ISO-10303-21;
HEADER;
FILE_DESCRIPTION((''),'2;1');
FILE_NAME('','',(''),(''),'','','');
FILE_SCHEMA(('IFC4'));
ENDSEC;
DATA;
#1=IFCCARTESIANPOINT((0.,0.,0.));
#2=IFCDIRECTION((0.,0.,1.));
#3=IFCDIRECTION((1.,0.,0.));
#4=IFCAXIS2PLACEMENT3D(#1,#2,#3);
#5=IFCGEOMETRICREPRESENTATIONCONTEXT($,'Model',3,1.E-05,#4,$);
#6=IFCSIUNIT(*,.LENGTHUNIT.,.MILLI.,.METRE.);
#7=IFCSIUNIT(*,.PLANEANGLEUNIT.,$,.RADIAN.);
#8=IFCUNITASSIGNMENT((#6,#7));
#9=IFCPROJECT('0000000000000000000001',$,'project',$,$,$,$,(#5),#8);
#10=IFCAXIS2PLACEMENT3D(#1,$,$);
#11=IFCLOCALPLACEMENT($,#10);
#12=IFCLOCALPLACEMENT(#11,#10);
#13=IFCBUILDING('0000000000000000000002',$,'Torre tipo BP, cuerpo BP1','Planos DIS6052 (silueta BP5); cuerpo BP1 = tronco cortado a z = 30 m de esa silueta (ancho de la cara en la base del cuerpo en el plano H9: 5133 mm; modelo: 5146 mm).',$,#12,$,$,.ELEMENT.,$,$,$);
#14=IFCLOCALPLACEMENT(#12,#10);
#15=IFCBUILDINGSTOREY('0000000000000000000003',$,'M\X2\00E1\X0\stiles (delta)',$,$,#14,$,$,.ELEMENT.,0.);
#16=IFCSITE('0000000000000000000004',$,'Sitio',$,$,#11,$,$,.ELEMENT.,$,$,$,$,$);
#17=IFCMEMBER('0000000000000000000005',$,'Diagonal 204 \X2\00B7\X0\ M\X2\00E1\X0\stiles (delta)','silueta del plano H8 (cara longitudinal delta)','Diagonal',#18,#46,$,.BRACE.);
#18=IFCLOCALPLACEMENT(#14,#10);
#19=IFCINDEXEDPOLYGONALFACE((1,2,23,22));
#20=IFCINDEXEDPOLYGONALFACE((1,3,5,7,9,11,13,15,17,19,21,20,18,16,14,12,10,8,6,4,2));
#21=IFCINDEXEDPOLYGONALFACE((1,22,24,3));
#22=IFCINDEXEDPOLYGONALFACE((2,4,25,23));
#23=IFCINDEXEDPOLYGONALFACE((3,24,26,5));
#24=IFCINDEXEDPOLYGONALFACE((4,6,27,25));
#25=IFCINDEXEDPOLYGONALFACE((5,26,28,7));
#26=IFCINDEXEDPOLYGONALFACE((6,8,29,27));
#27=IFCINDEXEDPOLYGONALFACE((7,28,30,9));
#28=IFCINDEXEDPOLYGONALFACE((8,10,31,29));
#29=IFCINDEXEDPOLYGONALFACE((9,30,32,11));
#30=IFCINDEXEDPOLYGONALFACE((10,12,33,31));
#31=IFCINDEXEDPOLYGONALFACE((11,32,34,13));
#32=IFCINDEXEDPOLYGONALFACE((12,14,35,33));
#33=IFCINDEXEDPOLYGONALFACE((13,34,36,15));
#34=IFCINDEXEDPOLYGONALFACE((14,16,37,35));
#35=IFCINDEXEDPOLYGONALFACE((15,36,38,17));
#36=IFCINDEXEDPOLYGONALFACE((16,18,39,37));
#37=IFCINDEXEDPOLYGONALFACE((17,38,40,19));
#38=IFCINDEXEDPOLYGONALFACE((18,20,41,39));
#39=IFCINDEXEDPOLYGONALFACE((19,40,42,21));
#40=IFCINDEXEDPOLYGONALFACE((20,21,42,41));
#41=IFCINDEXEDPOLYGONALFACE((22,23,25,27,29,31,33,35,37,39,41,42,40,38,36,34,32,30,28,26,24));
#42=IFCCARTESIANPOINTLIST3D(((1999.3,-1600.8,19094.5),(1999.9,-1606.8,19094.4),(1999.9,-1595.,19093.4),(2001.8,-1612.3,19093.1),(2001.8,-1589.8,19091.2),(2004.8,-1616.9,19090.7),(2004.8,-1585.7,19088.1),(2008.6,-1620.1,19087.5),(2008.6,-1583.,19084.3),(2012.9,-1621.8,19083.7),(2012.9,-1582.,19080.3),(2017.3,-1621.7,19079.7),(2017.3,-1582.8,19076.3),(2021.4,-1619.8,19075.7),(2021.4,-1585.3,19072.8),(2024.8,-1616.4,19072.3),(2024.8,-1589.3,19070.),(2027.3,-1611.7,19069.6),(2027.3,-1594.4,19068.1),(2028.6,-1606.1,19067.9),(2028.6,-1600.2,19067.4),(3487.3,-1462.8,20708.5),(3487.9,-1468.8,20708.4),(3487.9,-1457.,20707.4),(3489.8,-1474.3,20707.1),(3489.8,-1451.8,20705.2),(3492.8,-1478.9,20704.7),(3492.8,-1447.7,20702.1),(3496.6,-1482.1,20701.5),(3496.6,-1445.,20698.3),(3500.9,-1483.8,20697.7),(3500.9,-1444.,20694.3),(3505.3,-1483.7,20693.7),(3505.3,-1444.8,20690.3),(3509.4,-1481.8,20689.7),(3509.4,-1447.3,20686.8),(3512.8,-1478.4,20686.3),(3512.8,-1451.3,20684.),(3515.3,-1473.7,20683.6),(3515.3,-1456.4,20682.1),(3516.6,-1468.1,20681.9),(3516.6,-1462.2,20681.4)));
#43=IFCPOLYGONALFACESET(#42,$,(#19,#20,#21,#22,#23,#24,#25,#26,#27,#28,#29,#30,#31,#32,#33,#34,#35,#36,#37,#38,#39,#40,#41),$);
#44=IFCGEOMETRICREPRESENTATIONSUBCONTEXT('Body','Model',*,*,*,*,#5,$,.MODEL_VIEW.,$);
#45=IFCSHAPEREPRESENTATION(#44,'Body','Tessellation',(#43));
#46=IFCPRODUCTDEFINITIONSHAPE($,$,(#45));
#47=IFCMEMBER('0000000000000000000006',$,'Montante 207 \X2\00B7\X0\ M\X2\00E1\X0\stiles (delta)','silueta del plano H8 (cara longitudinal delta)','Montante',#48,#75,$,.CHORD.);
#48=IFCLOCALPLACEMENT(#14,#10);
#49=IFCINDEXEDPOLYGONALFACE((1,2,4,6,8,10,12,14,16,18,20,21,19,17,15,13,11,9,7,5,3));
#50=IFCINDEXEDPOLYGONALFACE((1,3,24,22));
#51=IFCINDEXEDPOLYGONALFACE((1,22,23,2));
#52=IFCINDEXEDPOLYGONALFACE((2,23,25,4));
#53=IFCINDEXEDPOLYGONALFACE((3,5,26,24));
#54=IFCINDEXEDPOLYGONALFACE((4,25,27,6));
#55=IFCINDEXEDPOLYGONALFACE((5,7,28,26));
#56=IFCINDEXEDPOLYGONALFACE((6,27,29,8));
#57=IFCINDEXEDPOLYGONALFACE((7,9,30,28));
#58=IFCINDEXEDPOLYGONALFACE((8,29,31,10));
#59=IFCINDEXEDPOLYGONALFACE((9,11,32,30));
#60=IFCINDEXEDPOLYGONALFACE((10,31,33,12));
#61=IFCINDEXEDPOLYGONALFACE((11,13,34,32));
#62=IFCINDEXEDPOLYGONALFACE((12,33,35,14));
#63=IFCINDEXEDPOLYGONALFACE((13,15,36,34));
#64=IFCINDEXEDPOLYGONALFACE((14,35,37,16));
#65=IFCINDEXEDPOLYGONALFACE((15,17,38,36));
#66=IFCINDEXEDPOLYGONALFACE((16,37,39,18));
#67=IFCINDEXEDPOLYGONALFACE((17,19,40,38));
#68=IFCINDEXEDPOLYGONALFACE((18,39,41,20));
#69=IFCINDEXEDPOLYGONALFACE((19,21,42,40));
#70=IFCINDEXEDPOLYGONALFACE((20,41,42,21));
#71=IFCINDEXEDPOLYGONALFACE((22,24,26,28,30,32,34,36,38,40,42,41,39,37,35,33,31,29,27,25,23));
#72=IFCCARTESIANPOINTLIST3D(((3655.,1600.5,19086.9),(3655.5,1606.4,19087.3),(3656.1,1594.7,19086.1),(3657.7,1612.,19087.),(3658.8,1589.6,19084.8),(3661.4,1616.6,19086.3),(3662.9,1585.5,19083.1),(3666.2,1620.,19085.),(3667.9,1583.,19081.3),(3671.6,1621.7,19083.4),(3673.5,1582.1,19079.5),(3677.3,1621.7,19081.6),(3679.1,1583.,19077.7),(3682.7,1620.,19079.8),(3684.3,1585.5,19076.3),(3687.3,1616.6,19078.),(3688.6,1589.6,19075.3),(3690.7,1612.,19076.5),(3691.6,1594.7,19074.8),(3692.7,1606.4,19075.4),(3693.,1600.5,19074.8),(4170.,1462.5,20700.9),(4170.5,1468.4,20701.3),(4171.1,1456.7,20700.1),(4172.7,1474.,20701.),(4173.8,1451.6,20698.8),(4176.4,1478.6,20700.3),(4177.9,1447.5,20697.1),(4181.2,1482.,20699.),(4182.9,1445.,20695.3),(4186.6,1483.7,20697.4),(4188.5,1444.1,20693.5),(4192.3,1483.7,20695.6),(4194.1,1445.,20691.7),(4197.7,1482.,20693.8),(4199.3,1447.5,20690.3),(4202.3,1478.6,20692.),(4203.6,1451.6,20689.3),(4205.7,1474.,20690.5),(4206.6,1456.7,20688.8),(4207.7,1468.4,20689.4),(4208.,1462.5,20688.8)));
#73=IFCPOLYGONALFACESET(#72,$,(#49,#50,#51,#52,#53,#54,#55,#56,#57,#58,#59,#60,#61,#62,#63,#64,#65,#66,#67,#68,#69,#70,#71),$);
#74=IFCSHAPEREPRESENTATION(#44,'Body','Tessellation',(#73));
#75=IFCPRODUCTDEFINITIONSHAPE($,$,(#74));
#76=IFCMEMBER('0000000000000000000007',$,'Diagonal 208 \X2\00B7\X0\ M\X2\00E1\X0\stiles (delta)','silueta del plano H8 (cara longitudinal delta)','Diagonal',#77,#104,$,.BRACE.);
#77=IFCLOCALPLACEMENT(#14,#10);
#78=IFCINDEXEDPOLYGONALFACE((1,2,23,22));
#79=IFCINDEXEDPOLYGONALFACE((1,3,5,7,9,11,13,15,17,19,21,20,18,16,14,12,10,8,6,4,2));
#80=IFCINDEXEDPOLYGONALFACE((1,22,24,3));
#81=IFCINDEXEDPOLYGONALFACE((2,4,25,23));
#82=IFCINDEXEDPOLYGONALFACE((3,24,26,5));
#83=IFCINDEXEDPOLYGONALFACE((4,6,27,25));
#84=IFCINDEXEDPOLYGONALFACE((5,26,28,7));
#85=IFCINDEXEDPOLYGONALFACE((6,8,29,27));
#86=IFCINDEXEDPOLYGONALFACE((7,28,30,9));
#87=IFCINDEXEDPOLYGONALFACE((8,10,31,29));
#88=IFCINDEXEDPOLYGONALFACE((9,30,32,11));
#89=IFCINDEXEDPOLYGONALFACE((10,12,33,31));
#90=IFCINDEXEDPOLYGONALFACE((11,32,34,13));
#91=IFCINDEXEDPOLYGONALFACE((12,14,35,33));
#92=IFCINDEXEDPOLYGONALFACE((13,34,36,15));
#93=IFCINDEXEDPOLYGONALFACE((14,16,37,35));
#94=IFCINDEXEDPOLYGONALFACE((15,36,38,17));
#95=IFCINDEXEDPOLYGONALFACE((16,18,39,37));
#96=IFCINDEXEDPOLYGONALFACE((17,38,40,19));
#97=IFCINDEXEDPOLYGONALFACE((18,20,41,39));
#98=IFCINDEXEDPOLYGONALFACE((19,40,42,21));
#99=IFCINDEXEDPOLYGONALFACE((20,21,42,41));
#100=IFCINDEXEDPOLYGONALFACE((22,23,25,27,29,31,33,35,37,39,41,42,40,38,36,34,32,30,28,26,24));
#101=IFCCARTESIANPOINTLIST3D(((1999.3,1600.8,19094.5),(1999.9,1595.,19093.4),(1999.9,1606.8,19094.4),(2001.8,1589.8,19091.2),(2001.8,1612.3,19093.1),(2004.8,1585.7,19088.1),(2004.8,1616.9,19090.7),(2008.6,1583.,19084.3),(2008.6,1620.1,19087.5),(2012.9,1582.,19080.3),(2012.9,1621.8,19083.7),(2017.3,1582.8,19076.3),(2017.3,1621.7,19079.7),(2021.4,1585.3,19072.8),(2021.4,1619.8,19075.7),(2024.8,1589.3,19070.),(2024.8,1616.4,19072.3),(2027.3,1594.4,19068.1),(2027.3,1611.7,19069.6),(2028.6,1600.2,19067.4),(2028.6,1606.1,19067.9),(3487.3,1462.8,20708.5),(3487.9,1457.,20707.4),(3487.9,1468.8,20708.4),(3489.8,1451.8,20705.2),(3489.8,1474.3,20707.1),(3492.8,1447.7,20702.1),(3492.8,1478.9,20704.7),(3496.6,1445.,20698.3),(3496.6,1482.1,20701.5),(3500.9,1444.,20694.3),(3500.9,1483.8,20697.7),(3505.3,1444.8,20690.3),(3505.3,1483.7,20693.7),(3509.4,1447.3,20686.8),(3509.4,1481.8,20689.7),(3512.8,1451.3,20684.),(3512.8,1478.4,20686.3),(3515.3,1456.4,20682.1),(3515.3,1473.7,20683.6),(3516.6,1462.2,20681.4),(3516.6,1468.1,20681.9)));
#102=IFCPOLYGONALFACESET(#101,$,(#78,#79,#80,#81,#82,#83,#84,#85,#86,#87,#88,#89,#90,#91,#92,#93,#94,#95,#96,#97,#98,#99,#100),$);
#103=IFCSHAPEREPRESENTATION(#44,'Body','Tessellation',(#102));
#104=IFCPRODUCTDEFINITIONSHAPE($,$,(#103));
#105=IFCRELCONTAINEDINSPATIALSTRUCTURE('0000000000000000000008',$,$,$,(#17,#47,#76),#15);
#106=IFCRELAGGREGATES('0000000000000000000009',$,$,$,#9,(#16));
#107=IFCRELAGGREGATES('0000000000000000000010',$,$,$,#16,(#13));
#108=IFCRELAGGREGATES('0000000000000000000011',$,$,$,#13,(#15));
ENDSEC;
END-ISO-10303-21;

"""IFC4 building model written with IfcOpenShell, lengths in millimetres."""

from ifc_helpers import new_model, si_unit, frame, origin, origin_with_axes, place, context, subcontext, project, spatial, circle, extrude, element, save


model = new_model("IFC4")

# Units and contexts
model_context = context("Model", 3, precision=1e-05, world=origin_with_axes())
body_context = subcontext(model_context, "Body", "Model", "MODEL_VIEW")
ifc_project = project(units=[si_unit("LENGTHUNIT", "METRE", prefix="MILLI"), si_unit("PLANEANGLEUNIT", "RADIAN")], contexts=[model_context])

# Site, building, storey
site_placement = place(None, origin())
site = spatial("IfcSite", under=ifc_project, at=site_placement, Name="Sitio", CompositionType="ELEMENT")
building_placement = place(site_placement, origin())
building = spatial("IfcBuilding", under=site, at=building_placement, Name="Torre tipo BP, cuerpo BP1", Description="Planos DIS6052 (silueta BP5); cuerpo BP1 = tronco cortado a z = 30 m de esa silueta (ancho de la cara en la base del cuerpo en el plano H9: 5133 mm; modelo: 5146 mm).", CompositionType="ELEMENT")
storey_placement = place(building_placement, origin())
storey = spatial("IfcBuildingStorey", under=building, at=storey_placement, Name="Mástiles (delta)", CompositionType="ELEMENT", Elevation=0.0)

# Members
member_1_placement = place(storey_placement, frame((3502.0, -1464.0, 20695.0), z_axis=(-0.676491, -0.062739, -0.733774), x_axis=(-0.736451, 0.057631, 0.674031)))
element("IfcMember", 1, at=member_1_placement, inside=storey, Name="Diagonal 204 · Mástiles (delta)", Description="silueta del plano H8 (cara longitudinal delta)", ObjectType="Diagonal", PredefinedType="BRACE", context=body_context, shape_type="SweptSolid", body=[
    extrude(circle(Radius=20.0), None, (0.0, 0.0, 1.0), 2199.6),
])
member_2_placement = place(storey_placement, frame((4189.0, 1464.0, 20695.0), z_axis=(-0.30298, 0.081187, -0.949533), x_axis=(-0.024679, -0.996699, -0.077345)))
element("IfcMember", 2, at=member_2_placement, inside=storey, Name="Montante 207 · Mástiles (delta)", Description="silueta del plano H8 (cara longitudinal delta)", ObjectType="Montante", PredefinedType="CHORD", context=body_context, shape_type="SweptSolid", body=[
    extrude(circle(Radius=20.0), None, (0.0, 0.0, 1.0), 1699.8),
])
member_3_placement = place(storey_placement, frame((3502.0, 1464.0, 20695.0), z_axis=(-0.676491, 0.062739, -0.733774), x_axis=(-0.736451, -0.057631, 0.674031)))
element("IfcMember", 3, at=member_3_placement, inside=storey, Name="Diagonal 208 · Mástiles (delta)", Description="silueta del plano H8 (cara longitudinal delta)", ObjectType="Diagonal", PredefinedType="BRACE", context=body_context, shape_type="SweptSolid", body=[
    extrude(circle(Radius=20.0), None, (0.0, 0.0, 1.0), 2199.6),
])

save(model, "model.ifc")
